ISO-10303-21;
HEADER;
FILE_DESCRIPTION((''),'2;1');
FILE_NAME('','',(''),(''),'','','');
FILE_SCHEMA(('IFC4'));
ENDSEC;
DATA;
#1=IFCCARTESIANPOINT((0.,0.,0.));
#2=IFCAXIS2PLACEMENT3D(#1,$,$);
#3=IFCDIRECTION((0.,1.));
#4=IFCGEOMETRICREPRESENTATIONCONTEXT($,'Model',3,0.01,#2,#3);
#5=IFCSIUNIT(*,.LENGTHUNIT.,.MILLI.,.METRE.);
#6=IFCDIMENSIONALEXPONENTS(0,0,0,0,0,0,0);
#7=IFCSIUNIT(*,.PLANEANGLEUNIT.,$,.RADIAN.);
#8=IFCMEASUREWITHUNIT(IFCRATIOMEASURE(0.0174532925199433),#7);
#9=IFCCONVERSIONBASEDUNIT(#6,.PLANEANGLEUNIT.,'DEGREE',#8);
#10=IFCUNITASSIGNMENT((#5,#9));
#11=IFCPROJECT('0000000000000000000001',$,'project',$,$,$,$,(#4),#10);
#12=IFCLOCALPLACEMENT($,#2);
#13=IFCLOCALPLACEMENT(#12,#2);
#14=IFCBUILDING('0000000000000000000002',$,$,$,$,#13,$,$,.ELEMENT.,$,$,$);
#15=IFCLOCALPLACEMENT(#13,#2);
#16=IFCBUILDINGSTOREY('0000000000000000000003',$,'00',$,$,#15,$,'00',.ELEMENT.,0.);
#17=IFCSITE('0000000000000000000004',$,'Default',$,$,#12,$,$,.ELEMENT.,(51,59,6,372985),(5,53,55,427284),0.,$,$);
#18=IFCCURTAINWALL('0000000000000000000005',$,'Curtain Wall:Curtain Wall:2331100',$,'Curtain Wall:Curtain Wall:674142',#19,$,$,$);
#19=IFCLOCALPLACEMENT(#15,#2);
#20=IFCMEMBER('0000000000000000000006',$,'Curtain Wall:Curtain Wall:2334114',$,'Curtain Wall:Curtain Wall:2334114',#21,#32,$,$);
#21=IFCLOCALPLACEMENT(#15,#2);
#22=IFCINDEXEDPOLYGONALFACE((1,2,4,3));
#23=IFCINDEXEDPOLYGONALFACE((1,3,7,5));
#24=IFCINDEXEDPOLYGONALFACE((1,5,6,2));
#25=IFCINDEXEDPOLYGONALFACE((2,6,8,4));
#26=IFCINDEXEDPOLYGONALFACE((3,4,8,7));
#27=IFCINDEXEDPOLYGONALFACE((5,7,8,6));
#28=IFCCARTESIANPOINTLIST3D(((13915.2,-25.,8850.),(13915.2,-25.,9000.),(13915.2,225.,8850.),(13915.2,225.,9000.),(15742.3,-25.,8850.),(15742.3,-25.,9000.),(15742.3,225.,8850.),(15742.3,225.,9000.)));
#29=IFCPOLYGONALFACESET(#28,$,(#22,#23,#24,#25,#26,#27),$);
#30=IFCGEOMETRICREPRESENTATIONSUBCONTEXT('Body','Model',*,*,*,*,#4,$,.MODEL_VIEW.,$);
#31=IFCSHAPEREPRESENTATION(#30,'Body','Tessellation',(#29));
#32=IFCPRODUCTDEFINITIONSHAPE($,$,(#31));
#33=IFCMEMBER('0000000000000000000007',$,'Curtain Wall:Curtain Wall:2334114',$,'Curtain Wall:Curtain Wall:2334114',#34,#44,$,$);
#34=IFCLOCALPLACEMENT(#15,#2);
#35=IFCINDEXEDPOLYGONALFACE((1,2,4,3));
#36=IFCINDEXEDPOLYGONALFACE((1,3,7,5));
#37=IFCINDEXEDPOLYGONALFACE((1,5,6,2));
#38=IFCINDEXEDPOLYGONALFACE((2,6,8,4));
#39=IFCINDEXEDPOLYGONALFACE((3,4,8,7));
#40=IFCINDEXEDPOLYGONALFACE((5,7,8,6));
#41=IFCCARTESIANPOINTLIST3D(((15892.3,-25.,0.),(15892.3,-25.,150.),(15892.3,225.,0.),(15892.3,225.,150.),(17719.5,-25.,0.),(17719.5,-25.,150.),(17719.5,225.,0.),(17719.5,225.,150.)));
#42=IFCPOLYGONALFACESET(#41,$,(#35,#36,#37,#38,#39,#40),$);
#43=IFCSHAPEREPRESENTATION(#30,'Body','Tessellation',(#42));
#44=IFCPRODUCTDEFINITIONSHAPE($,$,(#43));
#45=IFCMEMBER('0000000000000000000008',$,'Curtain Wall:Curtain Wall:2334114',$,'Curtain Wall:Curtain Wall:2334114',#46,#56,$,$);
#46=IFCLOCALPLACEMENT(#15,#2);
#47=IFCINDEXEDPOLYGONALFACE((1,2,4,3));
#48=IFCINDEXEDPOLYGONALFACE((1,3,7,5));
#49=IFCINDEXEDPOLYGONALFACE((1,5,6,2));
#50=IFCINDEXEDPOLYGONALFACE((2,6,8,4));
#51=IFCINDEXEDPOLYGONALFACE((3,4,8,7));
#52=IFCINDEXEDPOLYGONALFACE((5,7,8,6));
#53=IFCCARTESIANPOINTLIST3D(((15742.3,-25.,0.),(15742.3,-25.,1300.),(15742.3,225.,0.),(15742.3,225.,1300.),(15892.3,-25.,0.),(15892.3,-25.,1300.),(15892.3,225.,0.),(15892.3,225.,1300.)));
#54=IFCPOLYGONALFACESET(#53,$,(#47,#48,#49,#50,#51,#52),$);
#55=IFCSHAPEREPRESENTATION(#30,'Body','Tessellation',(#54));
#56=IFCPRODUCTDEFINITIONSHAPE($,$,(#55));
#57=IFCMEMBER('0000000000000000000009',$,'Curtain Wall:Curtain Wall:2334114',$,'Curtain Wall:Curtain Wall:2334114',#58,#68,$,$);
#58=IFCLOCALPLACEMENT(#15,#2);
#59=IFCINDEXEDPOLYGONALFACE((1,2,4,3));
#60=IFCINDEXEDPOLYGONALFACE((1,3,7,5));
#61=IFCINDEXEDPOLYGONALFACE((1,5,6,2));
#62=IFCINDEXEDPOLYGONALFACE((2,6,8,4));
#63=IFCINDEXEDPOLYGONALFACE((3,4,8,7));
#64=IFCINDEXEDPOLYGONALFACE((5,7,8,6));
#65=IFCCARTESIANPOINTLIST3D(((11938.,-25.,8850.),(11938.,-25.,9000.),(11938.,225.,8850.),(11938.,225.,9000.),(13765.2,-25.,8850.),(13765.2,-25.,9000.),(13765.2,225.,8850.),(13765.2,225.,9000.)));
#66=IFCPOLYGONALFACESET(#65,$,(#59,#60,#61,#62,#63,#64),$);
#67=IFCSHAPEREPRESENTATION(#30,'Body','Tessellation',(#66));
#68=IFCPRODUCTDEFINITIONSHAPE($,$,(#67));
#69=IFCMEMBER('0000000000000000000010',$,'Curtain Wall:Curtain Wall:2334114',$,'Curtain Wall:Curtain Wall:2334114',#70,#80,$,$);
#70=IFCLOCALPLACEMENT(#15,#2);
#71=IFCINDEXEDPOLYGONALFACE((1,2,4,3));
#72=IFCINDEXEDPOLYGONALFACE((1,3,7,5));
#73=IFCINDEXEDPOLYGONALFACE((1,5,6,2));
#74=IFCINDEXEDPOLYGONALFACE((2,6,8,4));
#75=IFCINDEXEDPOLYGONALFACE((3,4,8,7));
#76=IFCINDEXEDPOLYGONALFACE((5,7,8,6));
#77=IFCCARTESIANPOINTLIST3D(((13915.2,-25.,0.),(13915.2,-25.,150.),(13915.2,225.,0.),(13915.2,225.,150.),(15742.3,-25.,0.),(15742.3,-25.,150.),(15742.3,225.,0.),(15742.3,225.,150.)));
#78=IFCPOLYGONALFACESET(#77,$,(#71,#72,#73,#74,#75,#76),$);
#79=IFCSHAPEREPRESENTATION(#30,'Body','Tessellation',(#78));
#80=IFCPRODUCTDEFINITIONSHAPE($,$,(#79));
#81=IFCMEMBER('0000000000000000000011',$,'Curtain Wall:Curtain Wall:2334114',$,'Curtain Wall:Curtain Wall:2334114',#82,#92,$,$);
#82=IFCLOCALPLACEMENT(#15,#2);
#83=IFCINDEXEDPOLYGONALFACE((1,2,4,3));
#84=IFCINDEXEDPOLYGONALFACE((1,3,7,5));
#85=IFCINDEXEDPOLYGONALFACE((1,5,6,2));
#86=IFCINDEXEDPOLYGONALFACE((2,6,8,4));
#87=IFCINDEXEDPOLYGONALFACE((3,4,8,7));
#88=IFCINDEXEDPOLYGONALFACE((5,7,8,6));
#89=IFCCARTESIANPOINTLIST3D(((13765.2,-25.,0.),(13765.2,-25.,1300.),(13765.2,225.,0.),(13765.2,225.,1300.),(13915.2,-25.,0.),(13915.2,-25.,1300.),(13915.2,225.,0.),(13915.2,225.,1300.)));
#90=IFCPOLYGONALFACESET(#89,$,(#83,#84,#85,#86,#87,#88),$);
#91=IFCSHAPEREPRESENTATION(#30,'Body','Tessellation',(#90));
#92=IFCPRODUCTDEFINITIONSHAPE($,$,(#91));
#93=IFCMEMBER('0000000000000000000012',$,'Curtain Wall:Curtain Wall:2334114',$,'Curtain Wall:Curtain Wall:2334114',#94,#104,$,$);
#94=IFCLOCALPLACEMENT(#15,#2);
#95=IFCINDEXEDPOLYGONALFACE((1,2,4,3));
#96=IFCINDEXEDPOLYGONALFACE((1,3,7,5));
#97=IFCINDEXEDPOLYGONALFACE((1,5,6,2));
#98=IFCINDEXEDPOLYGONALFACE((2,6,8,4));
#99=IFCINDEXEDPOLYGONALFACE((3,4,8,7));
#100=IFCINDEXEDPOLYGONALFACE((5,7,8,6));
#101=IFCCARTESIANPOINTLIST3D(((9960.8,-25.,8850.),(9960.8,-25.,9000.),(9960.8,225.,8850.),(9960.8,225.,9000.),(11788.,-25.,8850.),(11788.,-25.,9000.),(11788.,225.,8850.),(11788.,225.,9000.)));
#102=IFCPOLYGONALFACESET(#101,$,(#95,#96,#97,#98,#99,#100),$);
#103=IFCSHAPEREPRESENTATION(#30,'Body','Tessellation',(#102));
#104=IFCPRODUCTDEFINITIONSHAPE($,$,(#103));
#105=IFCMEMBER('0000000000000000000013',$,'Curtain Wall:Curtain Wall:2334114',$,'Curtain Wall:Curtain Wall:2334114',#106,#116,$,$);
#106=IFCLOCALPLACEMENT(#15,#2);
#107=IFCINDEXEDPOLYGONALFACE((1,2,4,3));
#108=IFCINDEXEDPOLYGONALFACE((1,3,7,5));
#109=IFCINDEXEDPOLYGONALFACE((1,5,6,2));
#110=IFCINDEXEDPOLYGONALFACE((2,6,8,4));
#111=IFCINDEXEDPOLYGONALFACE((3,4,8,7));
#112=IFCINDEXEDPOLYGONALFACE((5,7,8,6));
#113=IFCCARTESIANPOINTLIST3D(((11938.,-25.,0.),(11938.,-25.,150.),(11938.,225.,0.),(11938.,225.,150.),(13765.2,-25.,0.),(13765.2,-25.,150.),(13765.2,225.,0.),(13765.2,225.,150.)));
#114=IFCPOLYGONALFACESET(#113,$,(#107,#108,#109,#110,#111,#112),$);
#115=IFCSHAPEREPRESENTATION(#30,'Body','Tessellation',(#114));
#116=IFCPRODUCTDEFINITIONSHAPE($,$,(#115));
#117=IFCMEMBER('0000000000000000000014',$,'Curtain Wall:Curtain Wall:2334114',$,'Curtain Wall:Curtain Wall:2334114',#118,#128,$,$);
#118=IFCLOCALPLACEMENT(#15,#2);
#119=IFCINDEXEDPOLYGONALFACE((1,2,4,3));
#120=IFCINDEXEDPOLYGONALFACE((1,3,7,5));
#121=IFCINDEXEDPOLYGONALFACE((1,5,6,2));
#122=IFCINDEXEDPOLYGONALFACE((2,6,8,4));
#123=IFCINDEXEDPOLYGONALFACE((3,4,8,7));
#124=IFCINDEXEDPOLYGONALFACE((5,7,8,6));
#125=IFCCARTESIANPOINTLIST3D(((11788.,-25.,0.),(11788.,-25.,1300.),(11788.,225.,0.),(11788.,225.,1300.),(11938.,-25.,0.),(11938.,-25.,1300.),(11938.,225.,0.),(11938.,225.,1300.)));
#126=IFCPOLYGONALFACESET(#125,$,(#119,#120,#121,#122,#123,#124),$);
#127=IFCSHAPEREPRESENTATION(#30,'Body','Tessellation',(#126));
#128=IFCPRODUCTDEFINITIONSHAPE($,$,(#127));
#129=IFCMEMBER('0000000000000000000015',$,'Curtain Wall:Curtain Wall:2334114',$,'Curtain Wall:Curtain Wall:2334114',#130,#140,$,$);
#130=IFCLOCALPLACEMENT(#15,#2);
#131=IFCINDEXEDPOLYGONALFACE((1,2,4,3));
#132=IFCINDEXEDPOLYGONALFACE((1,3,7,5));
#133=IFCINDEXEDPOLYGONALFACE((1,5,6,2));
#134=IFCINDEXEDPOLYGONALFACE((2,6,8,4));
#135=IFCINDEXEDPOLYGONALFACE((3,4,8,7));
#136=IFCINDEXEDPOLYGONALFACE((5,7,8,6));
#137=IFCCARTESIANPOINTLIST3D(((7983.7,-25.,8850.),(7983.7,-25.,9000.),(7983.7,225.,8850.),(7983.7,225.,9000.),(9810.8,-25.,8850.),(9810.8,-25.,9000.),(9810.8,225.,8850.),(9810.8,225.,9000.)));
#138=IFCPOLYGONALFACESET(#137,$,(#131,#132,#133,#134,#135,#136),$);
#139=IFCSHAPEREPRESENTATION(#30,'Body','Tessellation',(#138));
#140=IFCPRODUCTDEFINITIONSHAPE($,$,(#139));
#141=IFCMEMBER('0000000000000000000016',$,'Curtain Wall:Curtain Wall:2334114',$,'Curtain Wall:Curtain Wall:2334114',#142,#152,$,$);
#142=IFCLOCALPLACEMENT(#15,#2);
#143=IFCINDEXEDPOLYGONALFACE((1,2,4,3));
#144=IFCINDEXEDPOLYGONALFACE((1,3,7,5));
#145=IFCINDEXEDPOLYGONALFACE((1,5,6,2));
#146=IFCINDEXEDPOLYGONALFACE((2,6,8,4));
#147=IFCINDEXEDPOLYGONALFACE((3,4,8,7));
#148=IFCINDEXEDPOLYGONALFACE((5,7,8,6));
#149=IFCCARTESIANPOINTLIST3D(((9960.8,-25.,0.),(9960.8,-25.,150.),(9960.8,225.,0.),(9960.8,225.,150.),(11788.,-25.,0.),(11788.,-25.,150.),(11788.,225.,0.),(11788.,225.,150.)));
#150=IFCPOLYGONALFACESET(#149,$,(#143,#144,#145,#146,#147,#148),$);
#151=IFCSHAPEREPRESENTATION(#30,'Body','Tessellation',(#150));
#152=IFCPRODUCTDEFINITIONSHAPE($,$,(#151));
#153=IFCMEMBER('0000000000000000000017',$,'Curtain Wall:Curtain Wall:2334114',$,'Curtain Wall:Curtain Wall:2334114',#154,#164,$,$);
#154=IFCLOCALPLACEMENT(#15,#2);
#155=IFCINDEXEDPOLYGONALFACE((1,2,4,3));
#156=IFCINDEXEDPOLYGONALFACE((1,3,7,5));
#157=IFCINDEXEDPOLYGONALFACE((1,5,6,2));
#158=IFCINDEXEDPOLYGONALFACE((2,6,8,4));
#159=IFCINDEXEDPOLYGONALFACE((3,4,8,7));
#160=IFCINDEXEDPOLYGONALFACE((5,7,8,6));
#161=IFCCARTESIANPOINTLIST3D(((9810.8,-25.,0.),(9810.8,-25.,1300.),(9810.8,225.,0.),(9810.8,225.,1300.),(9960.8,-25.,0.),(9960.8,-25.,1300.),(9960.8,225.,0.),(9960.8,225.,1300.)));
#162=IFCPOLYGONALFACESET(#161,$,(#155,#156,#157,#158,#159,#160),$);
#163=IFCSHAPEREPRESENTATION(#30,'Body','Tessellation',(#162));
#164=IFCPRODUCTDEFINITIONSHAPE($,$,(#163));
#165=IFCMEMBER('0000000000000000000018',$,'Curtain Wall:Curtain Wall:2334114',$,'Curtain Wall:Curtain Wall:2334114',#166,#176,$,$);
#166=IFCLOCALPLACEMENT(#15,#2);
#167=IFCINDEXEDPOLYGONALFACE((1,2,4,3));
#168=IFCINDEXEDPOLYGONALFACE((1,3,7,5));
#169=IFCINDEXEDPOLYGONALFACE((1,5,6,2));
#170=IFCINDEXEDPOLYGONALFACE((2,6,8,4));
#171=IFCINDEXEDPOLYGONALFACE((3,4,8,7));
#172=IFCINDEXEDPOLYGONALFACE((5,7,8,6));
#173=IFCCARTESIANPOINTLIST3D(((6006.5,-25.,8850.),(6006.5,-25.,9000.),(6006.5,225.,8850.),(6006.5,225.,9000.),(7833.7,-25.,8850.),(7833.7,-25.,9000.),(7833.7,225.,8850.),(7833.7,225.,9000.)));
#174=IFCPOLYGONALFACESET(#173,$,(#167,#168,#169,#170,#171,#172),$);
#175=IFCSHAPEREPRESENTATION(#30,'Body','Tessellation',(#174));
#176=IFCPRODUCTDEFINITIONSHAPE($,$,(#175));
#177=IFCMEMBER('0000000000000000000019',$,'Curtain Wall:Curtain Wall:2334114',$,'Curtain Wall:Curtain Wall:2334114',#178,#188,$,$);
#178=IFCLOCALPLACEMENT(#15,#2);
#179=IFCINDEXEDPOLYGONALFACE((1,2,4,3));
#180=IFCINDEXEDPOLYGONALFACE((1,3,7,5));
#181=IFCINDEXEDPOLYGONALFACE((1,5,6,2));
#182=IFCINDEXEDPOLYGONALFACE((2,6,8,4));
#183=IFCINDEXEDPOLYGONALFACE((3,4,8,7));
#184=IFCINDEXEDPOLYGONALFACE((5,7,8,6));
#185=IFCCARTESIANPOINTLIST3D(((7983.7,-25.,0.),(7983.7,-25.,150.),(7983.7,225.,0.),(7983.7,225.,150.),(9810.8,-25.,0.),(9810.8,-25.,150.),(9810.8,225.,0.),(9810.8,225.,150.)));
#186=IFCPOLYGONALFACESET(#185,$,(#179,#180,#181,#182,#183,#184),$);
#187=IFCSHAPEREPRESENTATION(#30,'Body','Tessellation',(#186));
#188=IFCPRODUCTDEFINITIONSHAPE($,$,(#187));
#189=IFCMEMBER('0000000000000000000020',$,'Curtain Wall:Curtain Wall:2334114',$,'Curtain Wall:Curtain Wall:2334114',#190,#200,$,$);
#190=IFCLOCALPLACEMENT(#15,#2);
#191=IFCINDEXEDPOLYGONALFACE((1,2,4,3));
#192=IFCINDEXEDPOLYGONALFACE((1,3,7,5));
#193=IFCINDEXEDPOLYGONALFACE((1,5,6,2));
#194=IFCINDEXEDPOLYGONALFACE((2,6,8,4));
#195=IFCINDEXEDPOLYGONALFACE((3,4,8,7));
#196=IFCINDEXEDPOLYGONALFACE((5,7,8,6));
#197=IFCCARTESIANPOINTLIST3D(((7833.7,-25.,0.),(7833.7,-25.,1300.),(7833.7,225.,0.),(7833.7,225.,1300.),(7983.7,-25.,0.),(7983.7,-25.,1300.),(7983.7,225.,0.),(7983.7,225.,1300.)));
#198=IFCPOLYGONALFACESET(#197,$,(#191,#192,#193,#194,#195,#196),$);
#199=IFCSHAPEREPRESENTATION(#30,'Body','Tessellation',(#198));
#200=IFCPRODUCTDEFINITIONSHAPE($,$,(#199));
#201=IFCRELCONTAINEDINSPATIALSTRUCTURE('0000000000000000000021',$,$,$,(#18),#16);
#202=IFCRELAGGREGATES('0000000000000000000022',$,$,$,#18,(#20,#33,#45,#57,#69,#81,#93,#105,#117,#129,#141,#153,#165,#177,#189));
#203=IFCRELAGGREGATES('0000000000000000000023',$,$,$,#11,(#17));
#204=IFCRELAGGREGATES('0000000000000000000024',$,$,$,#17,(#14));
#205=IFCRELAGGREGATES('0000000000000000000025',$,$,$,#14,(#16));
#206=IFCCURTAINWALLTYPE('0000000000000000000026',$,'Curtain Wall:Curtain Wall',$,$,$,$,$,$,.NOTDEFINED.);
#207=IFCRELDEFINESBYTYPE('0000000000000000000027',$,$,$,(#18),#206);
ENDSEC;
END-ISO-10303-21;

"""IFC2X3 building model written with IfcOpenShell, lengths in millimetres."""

from ifc_helpers import new_model, entity, si_unit, converted_unit, direction, frame, frame_2d, origin, origin_2d_with_axis, place, context, subcontext, project, spatial, rectangle, extrude, type_object, element, aggregate, save


model = new_model("IFC2X3")

# Units and contexts
model_context = context("Model", 3, precision=0.01, world=origin(), true_north=direction((0.0, 1.0)))
body_context = subcontext(model_context, "Body", "Model", "MODEL_VIEW")
ifc_project = project(units=[si_unit("LENGTHUNIT", "METRE", prefix="MILLI"), converted_unit("PLANEANGLEUNIT", "DEGREE", entity("IfcRatioMeasure", 0.0174532925199433), si_unit("PLANEANGLEUNIT", "RADIAN"), dimensions=[0, 0, 0, 0, 0, 0, 0])], contexts=[model_context])

# Site, building, storey
site_placement = place(None, origin())
site = spatial("IfcSite", under=ifc_project, at=site_placement, Name="Default", CompositionType="ELEMENT", RefLatitude=(51, 59, 6, 372985), RefLongitude=(5, 53, 55, 427284), RefElevation=0.0)
building_placement = place(site_placement, origin())
building = spatial("IfcBuilding", under=site, at=building_placement, CompositionType="ELEMENT")
storey_placement = place(building_placement, origin())
storey = spatial("IfcBuildingStorey", under=building, at=storey_placement, Name="00", LongName="00", CompositionType="ELEMENT", Elevation=0.0)

# Curtain wall, members
curtain_wall_type = type_object("IfcCurtainWallType", Name="Curtain Wall:Curtain Wall", PredefinedType="NOTDEFINED")
curtain_wall_placement = place(storey_placement, origin())
curtain_wall = element("IfcCurtainWall", 1, at=curtain_wall_placement, inside=storey, type_object=curtain_wall_type, Name="Curtain Wall:Curtain Wall:2331100", ObjectType="Curtain Wall:Curtain Wall:674142")
member_1_placement = place(curtain_wall_placement, origin())
member_1 = element("IfcMember", 2, at=member_1_placement, Name="Curtain Wall:Curtain Wall:2334114", ObjectType="Curtain Wall:Curtain Wall:2334114", context=body_context, shape_type="SweptSolid", body=[
    extrude(rectangle(XDim=150.0, YDim=250.0, at=frame_2d((0.0, 0.0), x_axis=(1.0, 0.0))), frame((15742.3, 100.0, 8925.0), z_axis=(-1.0, 0.0, 0.0), x_axis=(0.0, 0.0, -1.0)), (0.0, 0.0, 1.0), 1827.2),
])
member_2_placement = place(curtain_wall_placement, origin())
member_2 = element("IfcMember", 3, at=member_2_placement, Name="Curtain Wall:Curtain Wall:2334114", ObjectType="Curtain Wall:Curtain Wall:2334114", context=body_context, shape_type="SweptSolid", body=[
    extrude(rectangle(XDim=150.0, YDim=250.0, at=frame_2d((0.0, 0.0), x_axis=(1.0, 0.0))), frame((15892.3, 100.0, 75.0), z_axis=(1.0, 0.0, 0.0), x_axis=(0.0, 0.0, -1.0)), (0.0, 0.0, 1.0), 1827.2),
])
member_3_placement = place(curtain_wall_placement, origin())
member_3 = element("IfcMember", 4, at=member_3_placement, Name="Curtain Wall:Curtain Wall:2334114", ObjectType="Curtain Wall:Curtain Wall:2334114", context=body_context, shape_type="SweptSolid", body=[
    extrude(rectangle(XDim=150.0, YDim=250.0, at=origin_2d_with_axis()), frame((15817.3, 100.0, 0.0), z_axis=(0.0, 0.0, 1.0), x_axis=(-1.0, 0.0, 0.0)), (0.0, 0.0, 1.0), 1300.0),
])
member_4_placement = place(curtain_wall_placement, origin())
member_4 = element("IfcMember", 5, at=member_4_placement, Name="Curtain Wall:Curtain Wall:2334114", ObjectType="Curtain Wall:Curtain Wall:2334114", context=body_context, shape_type="SweptSolid", body=[
    extrude(rectangle(XDim=150.0, YDim=250.0, at=frame_2d((0.0, 0.0), x_axis=(1.0, 0.0))), frame((13765.2, 100.0, 8925.0), z_axis=(-1.0, 0.0, 0.0), x_axis=(0.0, 0.0, -1.0)), (0.0, 0.0, 1.0), 1827.2),
])
member_5_placement = place(curtain_wall_placement, origin())
member_5 = element("IfcMember", 6, at=member_5_placement, Name="Curtain Wall:Curtain Wall:2334114", ObjectType="Curtain Wall:Curtain Wall:2334114", context=body_context, shape_type="SweptSolid", body=[
    extrude(rectangle(XDim=150.0, YDim=250.0, at=frame_2d((0.0, 0.0), x_axis=(1.0, 0.0))), frame((13915.2, 100.0, 75.0), z_axis=(1.0, 0.0, 0.0), x_axis=(0.0, 0.0, -1.0)), (0.0, 0.0, 1.0), 1827.2),
])
member_6_placement = place(curtain_wall_placement, origin())
member_6 = element("IfcMember", 7, at=member_6_placement, Name="Curtain Wall:Curtain Wall:2334114", ObjectType="Curtain Wall:Curtain Wall:2334114", context=body_context, shape_type="SweptSolid", body=[
    extrude(rectangle(XDim=150.0, YDim=250.0, at=origin_2d_with_axis()), frame((13840.2, 100.0, 0.0), z_axis=(0.0, 0.0, 1.0), x_axis=(-1.0, 0.0, 0.0)), (0.0, 0.0, 1.0), 1300.0),
])
member_7_placement = place(curtain_wall_placement, origin())
member_7 = element("IfcMember", 8, at=member_7_placement, Name="Curtain Wall:Curtain Wall:2334114", ObjectType="Curtain Wall:Curtain Wall:2334114", context=body_context, shape_type="SweptSolid", body=[
    extrude(rectangle(XDim=150.0, YDim=250.0, at=frame_2d((0.0, 0.0), x_axis=(1.0, 0.0))), frame((11788.0, 100.0, 8925.0), z_axis=(-1.0, 0.0, 0.0), x_axis=(0.0, 0.0, -1.0)), (0.0, 0.0, 1.0), 1827.2),
])
member_8_placement = place(curtain_wall_placement, origin())
member_8 = element("IfcMember", 9, at=member_8_placement, Name="Curtain Wall:Curtain Wall:2334114", ObjectType="Curtain Wall:Curtain Wall:2334114", context=body_context, shape_type="SweptSolid", body=[
    extrude(rectangle(XDim=150.0, YDim=250.0, at=frame_2d((0.0, 0.0), x_axis=(1.0, 0.0))), frame((11938.0, 100.0, 75.0), z_axis=(1.0, 0.0, 0.0), x_axis=(0.0, 0.0, -1.0)), (0.0, 0.0, 1.0), 1827.2),
])
member_9_placement = place(curtain_wall_placement, origin())
member_9 = element("IfcMember", 10, at=member_9_placement, Name="Curtain Wall:Curtain Wall:2334114", ObjectType="Curtain Wall:Curtain Wall:2334114", context=body_context, shape_type="SweptSolid", body=[
    extrude(rectangle(XDim=150.0, YDim=250.0, at=origin_2d_with_axis()), frame((11863.0, 100.0, 0.0), z_axis=(0.0, 0.0, 1.0), x_axis=(-1.0, 0.0, 0.0)), (0.0, 0.0, 1.0), 1300.0),
])
member_10_placement = place(curtain_wall_placement, origin())
member_10 = element("IfcMember", 11, at=member_10_placement, Name="Curtain Wall:Curtain Wall:2334114", ObjectType="Curtain Wall:Curtain Wall:2334114", context=body_context, shape_type="SweptSolid", body=[
    extrude(rectangle(XDim=150.0, YDim=250.0, at=frame_2d((0.0, 0.0), x_axis=(1.0, 0.0))), frame((9810.8, 100.0, 8925.0), z_axis=(-1.0, 0.0, 0.0), x_axis=(0.0, 0.0, -1.0)), (0.0, 0.0, 1.0), 1827.2),
])
member_11_placement = place(curtain_wall_placement, origin())
member_11 = element("IfcMember", 12, at=member_11_placement, Name="Curtain Wall:Curtain Wall:2334114", ObjectType="Curtain Wall:Curtain Wall:2334114", context=body_context, shape_type="SweptSolid", body=[
    extrude(rectangle(XDim=150.0, YDim=250.0, at=frame_2d((0.0, 0.0), x_axis=(1.0, 0.0))), frame((9960.8, 100.0, 75.0), z_axis=(1.0, 0.0, 0.0), x_axis=(0.0, 0.0, -1.0)), (0.0, 0.0, 1.0), 1827.2),
])
member_12_placement = place(curtain_wall_placement, origin())
member_12 = element("IfcMember", 13, at=member_12_placement, Name="Curtain Wall:Curtain Wall:2334114", ObjectType="Curtain Wall:Curtain Wall:2334114", context=body_context, shape_type="SweptSolid", body=[
    extrude(rectangle(XDim=150.0, YDim=250.0, at=origin_2d_with_axis()), frame((9885.8, 100.0, 0.0), z_axis=(0.0, 0.0, 1.0), x_axis=(-1.0, 0.0, 0.0)), (0.0, 0.0, 1.0), 1300.0),
])
member_13_placement = place(curtain_wall_placement, origin())
member_13 = element("IfcMember", 14, at=member_13_placement, Name="Curtain Wall:Curtain Wall:2334114", ObjectType="Curtain Wall:Curtain Wall:2334114", context=body_context, shape_type="SweptSolid", body=[
    extrude(rectangle(XDim=150.0, YDim=250.0, at=frame_2d((0.0, 0.0), x_axis=(1.0, 0.0))), frame((7833.7, 100.0, 8925.0), z_axis=(-1.0, 0.0, 0.0), x_axis=(0.0, 0.0, -1.0)), (0.0, 0.0, 1.0), 1827.2),
])
member_14_placement = place(curtain_wall_placement, origin())
member_14 = element("IfcMember", 15, at=member_14_placement, Name="Curtain Wall:Curtain Wall:2334114", ObjectType="Curtain Wall:Curtain Wall:2334114", context=body_context, shape_type="SweptSolid", body=[
    extrude(rectangle(XDim=150.0, YDim=250.0, at=frame_2d((0.0, 0.0), x_axis=(1.0, 0.0))), frame((7983.7, 100.0, 75.0), z_axis=(1.0, 0.0, 0.0), x_axis=(0.0, 0.0, -1.0)), (0.0, 0.0, 1.0), 1827.2),
])
member_15_placement = place(curtain_wall_placement, origin())
member_15 = element("IfcMember", 16, at=member_15_placement, Name="Curtain Wall:Curtain Wall:2334114", ObjectType="Curtain Wall:Curtain Wall:2334114", context=body_context, shape_type="SweptSolid", body=[
    extrude(rectangle(XDim=150.0, YDim=250.0, at=frame_2d((0.0, 0.0), x_axis=(1.0, 0.0))), frame((7908.7, 100.0, 0.0), z_axis=(0.0, 0.0, 1.0), x_axis=(-1.0, 0.0, 0.0)), (0.0, 0.0, 1.0), 1300.0),
])
aggregate(curtain_wall, [member_1, member_2, member_3, member_4, member_5, member_6, member_7, member_8, member_9, member_10, member_11, member_12, member_13, member_14, member_15])

save(model, "model.ifc")
